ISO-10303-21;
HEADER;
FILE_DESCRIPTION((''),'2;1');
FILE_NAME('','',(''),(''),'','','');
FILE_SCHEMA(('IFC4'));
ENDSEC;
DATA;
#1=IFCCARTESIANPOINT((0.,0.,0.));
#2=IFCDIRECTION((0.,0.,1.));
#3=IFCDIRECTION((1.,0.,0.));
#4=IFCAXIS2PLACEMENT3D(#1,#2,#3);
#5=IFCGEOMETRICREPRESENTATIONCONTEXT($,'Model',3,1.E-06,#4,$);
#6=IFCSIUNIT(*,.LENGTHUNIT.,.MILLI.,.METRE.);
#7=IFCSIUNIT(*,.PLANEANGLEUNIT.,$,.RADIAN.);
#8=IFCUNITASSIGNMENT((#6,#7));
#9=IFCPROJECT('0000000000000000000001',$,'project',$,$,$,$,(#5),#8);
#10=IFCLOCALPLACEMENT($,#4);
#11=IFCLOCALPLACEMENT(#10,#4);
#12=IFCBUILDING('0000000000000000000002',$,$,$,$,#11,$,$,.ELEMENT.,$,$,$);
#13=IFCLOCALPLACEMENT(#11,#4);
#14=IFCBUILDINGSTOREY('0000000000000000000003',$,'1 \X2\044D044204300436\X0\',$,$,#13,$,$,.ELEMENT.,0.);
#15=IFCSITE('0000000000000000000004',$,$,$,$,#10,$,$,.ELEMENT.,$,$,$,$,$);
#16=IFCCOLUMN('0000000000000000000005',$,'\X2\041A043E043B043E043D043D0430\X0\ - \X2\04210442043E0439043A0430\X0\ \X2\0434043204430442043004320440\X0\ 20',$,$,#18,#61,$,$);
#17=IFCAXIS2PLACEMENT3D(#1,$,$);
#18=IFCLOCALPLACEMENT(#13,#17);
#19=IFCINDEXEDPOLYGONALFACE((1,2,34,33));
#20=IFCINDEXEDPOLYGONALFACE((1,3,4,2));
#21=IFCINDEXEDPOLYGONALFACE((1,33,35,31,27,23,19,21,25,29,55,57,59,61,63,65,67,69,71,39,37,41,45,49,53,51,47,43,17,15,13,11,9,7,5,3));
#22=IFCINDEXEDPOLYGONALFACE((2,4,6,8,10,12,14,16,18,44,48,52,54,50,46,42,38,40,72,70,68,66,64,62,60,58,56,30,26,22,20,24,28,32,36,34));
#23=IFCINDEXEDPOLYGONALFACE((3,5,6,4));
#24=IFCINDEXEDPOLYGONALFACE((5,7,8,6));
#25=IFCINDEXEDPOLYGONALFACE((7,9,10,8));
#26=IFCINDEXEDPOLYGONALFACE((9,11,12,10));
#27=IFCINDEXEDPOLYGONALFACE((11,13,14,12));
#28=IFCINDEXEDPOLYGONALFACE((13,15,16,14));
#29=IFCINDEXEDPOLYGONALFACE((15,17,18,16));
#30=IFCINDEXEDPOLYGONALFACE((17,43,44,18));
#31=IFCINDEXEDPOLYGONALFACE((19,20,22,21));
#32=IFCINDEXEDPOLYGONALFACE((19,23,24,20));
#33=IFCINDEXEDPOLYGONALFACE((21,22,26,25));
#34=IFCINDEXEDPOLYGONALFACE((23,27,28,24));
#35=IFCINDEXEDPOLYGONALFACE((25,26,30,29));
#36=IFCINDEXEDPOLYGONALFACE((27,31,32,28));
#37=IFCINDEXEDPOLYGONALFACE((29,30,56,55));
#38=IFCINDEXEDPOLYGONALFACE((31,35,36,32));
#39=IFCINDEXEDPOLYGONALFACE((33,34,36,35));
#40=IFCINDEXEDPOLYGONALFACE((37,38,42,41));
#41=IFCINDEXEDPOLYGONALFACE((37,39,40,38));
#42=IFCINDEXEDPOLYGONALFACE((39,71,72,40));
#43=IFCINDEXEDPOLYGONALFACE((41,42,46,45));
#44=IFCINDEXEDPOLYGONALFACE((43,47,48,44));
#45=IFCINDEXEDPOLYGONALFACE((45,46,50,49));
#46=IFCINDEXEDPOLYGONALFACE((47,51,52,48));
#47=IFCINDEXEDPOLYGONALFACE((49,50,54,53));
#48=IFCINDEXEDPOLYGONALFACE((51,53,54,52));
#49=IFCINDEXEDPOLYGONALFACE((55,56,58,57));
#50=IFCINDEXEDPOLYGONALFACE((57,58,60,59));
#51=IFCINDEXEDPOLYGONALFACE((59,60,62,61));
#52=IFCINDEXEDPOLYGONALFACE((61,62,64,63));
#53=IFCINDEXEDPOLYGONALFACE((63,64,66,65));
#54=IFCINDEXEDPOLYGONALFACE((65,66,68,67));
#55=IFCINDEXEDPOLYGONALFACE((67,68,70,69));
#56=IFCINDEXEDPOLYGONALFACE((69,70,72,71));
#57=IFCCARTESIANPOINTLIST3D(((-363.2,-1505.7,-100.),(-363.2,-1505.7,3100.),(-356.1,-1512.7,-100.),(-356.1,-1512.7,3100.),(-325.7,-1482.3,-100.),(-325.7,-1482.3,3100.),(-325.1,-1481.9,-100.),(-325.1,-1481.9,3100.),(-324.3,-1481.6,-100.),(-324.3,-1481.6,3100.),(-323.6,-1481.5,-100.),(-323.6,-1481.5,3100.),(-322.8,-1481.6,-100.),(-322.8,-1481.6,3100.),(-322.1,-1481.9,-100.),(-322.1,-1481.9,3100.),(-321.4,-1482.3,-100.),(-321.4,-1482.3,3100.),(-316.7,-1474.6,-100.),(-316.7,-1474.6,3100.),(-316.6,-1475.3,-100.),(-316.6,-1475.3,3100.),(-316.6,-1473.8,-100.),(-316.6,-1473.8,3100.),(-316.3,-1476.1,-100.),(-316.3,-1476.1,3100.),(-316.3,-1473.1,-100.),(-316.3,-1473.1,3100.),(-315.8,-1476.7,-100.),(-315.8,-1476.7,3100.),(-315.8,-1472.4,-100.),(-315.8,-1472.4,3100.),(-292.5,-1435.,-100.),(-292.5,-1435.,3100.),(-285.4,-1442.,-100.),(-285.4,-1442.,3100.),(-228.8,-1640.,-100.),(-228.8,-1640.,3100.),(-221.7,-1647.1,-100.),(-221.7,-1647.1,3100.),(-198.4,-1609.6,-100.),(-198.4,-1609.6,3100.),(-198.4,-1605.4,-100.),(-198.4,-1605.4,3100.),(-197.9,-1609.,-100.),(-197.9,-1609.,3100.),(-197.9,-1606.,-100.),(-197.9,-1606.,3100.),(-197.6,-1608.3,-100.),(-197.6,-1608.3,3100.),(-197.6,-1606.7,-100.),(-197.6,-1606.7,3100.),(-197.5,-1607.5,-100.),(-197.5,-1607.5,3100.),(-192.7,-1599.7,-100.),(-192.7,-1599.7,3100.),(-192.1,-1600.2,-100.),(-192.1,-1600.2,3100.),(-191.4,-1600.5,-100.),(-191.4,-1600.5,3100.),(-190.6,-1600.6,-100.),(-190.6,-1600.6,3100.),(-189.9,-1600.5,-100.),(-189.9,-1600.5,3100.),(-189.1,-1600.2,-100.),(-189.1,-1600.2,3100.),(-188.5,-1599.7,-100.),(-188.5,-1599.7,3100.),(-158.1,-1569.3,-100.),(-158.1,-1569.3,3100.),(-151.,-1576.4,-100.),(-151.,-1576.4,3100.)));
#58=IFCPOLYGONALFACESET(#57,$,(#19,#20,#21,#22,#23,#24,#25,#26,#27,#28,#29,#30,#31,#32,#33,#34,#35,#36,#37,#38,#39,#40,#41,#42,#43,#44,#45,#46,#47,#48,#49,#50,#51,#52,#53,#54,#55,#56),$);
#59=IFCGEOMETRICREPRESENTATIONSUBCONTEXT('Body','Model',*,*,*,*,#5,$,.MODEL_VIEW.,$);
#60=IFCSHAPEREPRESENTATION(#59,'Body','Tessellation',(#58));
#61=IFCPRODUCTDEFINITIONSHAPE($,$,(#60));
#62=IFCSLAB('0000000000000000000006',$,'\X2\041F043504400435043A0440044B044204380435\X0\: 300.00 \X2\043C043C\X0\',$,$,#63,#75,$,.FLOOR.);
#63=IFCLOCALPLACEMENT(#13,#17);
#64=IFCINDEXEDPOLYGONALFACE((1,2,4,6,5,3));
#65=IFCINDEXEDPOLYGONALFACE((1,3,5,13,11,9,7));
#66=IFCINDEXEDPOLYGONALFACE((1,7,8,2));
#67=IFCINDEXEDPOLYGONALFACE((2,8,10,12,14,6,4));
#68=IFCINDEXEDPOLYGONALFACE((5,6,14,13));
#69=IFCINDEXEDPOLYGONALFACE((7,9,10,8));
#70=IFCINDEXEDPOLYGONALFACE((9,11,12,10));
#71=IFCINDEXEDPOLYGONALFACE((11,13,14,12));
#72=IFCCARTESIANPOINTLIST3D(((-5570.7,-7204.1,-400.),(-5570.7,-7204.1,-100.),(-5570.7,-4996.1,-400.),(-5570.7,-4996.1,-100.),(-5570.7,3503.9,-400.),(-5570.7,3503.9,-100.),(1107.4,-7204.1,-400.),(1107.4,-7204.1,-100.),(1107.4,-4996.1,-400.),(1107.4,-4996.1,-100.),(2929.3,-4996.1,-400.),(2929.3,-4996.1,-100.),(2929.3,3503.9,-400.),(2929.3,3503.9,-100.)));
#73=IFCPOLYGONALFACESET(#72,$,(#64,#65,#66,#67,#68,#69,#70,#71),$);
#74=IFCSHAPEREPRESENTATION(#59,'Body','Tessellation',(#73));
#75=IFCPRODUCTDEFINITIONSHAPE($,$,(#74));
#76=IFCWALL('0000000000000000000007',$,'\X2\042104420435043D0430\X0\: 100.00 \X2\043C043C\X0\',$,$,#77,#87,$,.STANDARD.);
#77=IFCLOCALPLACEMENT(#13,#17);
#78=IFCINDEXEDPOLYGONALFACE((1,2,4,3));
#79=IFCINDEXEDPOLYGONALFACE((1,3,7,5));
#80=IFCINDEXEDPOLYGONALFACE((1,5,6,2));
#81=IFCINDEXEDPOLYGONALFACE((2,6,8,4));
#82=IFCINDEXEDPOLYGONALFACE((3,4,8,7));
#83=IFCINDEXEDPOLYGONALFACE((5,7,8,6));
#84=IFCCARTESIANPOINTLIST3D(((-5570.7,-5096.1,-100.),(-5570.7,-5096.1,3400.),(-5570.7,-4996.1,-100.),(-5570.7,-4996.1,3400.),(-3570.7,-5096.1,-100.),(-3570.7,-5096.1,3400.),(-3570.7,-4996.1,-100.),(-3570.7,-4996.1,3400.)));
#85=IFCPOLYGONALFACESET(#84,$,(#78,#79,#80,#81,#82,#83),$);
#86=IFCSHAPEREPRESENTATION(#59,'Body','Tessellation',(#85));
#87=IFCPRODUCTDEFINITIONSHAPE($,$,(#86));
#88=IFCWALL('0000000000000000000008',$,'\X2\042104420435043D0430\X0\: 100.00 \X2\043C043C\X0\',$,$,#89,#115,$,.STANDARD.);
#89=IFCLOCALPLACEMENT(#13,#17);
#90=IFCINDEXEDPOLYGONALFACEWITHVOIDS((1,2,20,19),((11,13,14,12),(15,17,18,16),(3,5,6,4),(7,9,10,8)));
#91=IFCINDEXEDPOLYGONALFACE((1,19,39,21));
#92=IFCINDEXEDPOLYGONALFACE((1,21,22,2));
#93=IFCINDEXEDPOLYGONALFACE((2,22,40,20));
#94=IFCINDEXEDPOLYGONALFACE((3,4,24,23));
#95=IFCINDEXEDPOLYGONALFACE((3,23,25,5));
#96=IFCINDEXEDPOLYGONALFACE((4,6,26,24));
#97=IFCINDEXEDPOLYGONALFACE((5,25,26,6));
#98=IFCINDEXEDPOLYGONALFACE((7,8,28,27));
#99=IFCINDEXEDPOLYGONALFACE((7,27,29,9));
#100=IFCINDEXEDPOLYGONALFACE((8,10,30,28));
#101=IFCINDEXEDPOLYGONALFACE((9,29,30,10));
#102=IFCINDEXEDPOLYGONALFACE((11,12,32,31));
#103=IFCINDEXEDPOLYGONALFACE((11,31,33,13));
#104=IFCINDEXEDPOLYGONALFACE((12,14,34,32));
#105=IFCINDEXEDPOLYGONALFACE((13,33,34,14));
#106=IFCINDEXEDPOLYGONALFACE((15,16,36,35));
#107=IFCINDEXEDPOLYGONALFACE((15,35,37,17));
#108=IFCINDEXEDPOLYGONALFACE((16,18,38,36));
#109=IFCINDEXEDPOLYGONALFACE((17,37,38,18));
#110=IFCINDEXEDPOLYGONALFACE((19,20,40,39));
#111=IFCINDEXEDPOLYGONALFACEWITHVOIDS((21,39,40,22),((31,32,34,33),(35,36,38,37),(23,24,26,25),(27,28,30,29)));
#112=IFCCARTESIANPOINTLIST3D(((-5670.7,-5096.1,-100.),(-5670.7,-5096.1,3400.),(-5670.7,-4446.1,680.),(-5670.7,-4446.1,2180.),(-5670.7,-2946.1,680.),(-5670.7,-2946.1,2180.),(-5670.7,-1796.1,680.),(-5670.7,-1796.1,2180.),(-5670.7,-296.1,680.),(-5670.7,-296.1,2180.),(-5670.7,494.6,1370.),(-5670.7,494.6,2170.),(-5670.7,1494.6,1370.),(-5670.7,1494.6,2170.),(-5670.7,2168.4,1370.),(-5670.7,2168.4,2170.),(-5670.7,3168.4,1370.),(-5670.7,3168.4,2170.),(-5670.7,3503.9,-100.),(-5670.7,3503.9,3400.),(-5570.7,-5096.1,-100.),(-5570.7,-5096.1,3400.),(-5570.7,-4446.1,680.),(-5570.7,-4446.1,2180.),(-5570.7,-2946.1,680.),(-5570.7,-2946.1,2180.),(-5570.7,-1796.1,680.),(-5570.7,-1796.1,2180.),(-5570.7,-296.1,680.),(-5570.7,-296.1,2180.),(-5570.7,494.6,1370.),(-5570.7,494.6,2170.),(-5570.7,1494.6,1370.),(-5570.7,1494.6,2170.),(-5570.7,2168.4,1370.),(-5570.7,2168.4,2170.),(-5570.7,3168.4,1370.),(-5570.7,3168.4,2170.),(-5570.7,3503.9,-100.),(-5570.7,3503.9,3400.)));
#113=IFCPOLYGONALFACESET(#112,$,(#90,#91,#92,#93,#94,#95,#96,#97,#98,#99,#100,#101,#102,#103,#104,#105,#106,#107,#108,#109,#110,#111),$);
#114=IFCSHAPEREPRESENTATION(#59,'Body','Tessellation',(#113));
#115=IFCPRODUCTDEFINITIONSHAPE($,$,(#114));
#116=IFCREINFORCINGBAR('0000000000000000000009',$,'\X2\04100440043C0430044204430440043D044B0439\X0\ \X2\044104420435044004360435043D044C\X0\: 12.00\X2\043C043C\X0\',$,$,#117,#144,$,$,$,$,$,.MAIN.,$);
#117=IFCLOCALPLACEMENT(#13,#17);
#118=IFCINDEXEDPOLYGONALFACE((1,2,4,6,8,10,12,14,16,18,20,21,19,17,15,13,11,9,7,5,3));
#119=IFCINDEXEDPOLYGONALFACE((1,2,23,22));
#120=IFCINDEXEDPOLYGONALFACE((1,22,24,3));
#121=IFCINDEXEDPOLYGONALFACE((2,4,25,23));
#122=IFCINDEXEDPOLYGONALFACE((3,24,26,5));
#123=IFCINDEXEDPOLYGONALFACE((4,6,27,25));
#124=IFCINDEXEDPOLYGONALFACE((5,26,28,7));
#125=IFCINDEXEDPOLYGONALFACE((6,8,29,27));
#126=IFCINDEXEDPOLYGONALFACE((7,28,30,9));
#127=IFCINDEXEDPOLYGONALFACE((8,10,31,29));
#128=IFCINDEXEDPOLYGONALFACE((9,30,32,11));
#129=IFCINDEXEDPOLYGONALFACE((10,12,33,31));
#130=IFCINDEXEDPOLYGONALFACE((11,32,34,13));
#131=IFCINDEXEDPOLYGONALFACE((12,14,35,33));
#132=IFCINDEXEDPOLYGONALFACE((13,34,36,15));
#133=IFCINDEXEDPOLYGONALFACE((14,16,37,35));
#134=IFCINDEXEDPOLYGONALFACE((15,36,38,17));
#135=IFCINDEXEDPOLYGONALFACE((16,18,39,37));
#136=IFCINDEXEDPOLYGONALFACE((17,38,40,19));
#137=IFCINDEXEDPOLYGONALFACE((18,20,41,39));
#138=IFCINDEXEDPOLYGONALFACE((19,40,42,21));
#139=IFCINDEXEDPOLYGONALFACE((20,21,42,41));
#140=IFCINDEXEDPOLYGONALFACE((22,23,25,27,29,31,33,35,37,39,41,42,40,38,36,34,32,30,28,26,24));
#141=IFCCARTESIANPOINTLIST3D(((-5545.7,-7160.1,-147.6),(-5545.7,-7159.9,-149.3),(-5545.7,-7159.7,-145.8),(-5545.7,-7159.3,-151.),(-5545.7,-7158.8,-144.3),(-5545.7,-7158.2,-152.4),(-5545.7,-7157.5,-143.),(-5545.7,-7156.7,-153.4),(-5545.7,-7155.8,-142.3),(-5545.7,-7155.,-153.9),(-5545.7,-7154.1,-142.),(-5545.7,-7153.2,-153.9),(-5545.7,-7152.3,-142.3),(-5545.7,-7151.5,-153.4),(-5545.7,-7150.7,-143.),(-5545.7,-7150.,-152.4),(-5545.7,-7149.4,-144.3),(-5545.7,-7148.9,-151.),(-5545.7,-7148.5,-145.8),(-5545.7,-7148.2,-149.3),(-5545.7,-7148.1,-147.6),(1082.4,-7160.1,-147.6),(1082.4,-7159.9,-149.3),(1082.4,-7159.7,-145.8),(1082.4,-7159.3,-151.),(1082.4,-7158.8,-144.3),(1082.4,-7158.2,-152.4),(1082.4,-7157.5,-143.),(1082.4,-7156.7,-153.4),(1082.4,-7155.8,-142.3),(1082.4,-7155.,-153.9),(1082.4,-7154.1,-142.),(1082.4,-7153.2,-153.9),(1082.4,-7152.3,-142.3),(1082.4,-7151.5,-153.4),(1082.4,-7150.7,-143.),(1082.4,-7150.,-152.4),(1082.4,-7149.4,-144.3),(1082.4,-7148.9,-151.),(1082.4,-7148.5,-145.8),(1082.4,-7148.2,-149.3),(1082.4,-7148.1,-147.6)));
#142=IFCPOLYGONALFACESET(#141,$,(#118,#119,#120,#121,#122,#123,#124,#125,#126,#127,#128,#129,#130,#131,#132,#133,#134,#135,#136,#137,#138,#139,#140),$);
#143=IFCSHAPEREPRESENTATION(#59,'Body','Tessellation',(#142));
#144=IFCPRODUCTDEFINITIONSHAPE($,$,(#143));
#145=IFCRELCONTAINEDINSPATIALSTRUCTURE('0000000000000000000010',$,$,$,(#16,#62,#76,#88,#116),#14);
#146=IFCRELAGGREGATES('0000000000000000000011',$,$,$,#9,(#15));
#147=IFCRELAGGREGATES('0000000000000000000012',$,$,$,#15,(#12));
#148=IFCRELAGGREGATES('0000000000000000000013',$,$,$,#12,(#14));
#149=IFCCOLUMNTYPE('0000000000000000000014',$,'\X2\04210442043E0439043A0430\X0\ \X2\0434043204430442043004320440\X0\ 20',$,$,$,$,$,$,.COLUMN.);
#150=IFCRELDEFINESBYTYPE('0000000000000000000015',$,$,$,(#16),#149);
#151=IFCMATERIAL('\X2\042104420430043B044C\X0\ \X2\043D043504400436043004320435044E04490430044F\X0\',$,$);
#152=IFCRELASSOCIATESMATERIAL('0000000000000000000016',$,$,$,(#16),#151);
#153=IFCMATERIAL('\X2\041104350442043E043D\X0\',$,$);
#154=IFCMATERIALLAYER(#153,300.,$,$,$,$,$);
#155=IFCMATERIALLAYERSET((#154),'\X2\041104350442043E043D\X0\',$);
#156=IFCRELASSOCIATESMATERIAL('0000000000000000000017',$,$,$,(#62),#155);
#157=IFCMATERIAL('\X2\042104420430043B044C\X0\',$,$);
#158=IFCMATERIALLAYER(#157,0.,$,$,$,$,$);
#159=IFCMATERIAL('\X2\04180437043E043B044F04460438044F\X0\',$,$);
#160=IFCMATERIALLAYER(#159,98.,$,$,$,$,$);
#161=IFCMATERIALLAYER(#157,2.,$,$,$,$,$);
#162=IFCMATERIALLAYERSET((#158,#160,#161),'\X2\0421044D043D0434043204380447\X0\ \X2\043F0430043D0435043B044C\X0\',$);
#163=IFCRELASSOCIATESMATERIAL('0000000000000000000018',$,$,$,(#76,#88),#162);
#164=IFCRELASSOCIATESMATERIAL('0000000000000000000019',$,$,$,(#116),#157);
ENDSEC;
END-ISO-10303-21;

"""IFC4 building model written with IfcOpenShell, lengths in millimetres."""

from ifc_helpers import new_model, entity, si_unit, frame, origin_with_axes, place, context, subcontext, project, spatial, line, arc, indexed_curve, outline, extrude, source, transform, mapped, material, layer, layer_set, layer_usage, type_object, element, save


model = new_model("IFC4")

# Units and contexts
model_context = context("Model", 3, precision=1e-06, world=origin_with_axes())
body_context = subcontext(model_context, "Body", "Model", "MODEL_VIEW")
ifc_project = project(units=[si_unit("LENGTHUNIT", "METRE", prefix="MILLI"), si_unit("PLANEANGLEUNIT", "RADIAN")], contexts=[model_context])

# Site, building, storey
site_placement = place(None, origin_with_axes())
site = spatial("IfcSite", under=ifc_project, at=site_placement, CompositionType="ELEMENT")
building_placement = place(site_placement, origin_with_axes())
building = spatial("IfcBuilding", under=site, at=building_placement, CompositionType="ELEMENT")
storey_placement = place(building_placement, origin_with_axes())
storey = spatial("IfcBuildingStorey", under=building, at=storey_placement, Name="1 этаж", CompositionType="ELEMENT", Elevation=0.0)

# Column
ifc_material_1 = material(Name="Сталь нержавеющая")
column_type = type_object("IfcColumnType", Name="Стойка двутавр 20", PredefinedType="COLUMN")
shared_shape_1 = source(origin_with_axes(), body_context, "Body", "SweptSolid", [
    extrude(outline(indexed_curve([(-50.0, -100.0), (50.0, -100.0), (50.0, -90.0), (7.0, -90.0), (4.9, -89.1), (4.0, -87.0), (4.0, 87.0), (4.9, 89.1), (7.0, 90.0), (50.0, 90.0), (50.0, 100.0), (-50.0, 100.0), (-50.0, 90.0), (-7.0, 90.0), (-4.9, 89.1), (-4.0, 87.0), (-4.0, -87.0), (-4.9, -89.1), (-7.0, -90.0), (-50.0, -90.0)], segments=[line(1, 2), line(2, 3), line(3, 4), arc(4, 5, 6), line(6, 7), arc(7, 8, 9), line(9, 10), line(10, 11), line(11, 12), line(12, 13), line(13, 14), arc(14, 15, 16), line(16, 17), arc(17, 18, 19), line(19, 20), line(20, 1)])), origin_with_axes(), (0.0, 0.0, 1.0), 3200.0),
])
for number, where, z_axis, x_axis, name in (
    (1, (-257.1, -1541.0, -100.0), (0.0, 0.0, 1.0), (0.707107, 0.707107, 0.0), "Колонна - Стойка двутавр 20"),
):
    element("IfcColumn", number, at=place(storey_placement, frame(where, z_axis=z_axis, x_axis=x_axis)), inside=storey, type_object=column_type, material=ifc_material_1, Name=name, context=body_context, shape_type="MappedRepresentation", body=[
        mapped(shared_shape_1, transform((0.0, 0.0, 0.0), x_axis=(1.0, 0.0, 0.0), y_axis=(0.0, 1.0, 0.0), z_axis=(0.0, 0.0, 1.0), scale=1.0)),
    ])

# Slab
ifc_material_2 = material(Name="Бетон")
ifc_layer_1 = layer(ifc_material_2, 300.0)
ifc_layer_set_1 = layer_set([ifc_layer_1], Name="Бетон")
ifc_layer_usage_1 = layer_usage(ifc_layer_set_1, "AXIS3", "NEGATIVE", -300.0)
slab_placement = place(storey_placement, frame((-5570.7, -4996.1, -400.0), z_axis=(0.0, 0.0, 1.0), x_axis=(0.0, 1.0, 0.0)))
element("IfcSlab", 2, at=slab_placement, inside=storey, material=ifc_layer_usage_1, Name="Перекрытие: 300.00 мм", PredefinedType="FLOOR", context=body_context, shape_type="SweptSolid", body=[
    extrude(outline(indexed_curve([(0.0, 0.0), (8500.0, 0.0), (8500.0, -8500.0), (0.0, -8500.0), (0.0, -6678.1), (-2208.0, -6678.1), (-2208.0, 0.0)], segments=[line(1, 2), line(2, 3), line(3, 4), line(4, 5), line(5, 6), line(6, 7), line(7, 1)])), origin_with_axes(), (0.0, 0.0, 1.0), 300.0),
])

# Wall
ifc_material_3 = material(Name="Сталь")
ifc_layer_2 = layer(ifc_material_3, 0.0)
ifc_material_4 = material(Name="Изоляция")
ifc_layer_3 = layer(ifc_material_4, 98.0)
ifc_layer_4 = layer(ifc_material_3, 2.0)
ifc_layer_set_2 = layer_set([ifc_layer_2, ifc_layer_3, ifc_layer_4], Name="Сэндвич панель")
ifc_layer_usage_2 = layer_usage(ifc_layer_set_2, "AXIS2", "NEGATIVE", 100.0)
wall_1_placement = place(storey_placement, frame((-3570.7, -4996.1, -100.0), z_axis=(0.0, 0.0, 1.0), x_axis=(-1.0, 0.0, 0.0)))
element("IfcWall", 3, at=wall_1_placement, inside=storey, material=ifc_layer_usage_2, Name="Стена: 100.00 мм", PredefinedType="STANDARD", context=body_context, shape_type="SweptSolid", body=[
    extrude(outline(indexed_curve([(0.0, 0.0), (2000.0, 0.0), (2000.0, 100.0), (0.0, 100.0)], segments=[line(1, 2), line(2, 3), line(3, 4), line(4, 1)])), origin_with_axes(), (0.0, 0.0, 1.0), 3500.0),
])

# Wall, openings
wall_2_placement = place(storey_placement, frame((-5570.7, -5096.1, -100.0), z_axis=(0.0, 0.0, 1.0), x_axis=(0.0, 1.0, 0.0)))
wall_2 = element("IfcWall", 4, at=wall_2_placement, inside=storey, material=ifc_layer_usage_2, Name="Стена: 100.00 мм", PredefinedType="STANDARD", context=body_context, shape_type="SweptSolid", body=[
    extrude(outline(indexed_curve([(0.0, 0.0), (8600.0, 0.0), (8600.0, 100.0), (0.0, 100.0)], segments=[line(1, 2), line(2, 3), line(3, 4), line(4, 1)])), origin_with_axes(), (0.0, 0.0, 1.0), 3500.0),
])
opening_1_placement = place(wall_2_placement, frame((2150.0, 100.0, 780.0), z_axis=(0.0, 0.0, 1.0), x_axis=(-1.0, 0.0, 0.0)))
element("IfcOpeningElement", 5, at=opening_1_placement, cuts=wall_2, PredefinedType="OPENING", context=body_context, shape_type="SweptSolid", body=[
    extrude(outline(indexed_curve([(0.0, 0.0), (1500.0, 0.0), (1500.0, 1500.0), (0.0, 1500.0)], segments=[line(1, 2), line(2, 3), line(3, 4), line(4, 1)])), frame((0.0, -5.0, 0.0), z_axis=(0.0, -1.0, 0.0), x_axis=(1.0, 0.0, 0.0)), (0.0, 0.0, -1.0), 110.0),
])
opening_2_placement = place(wall_2_placement, frame((4800.0, 100.0, 780.0), z_axis=(0.0, 0.0, 1.0), x_axis=(-1.0, 0.0, 0.0)))
element("IfcOpeningElement", 6, at=opening_2_placement, cuts=wall_2, PredefinedType="OPENING", context=body_context, shape_type="SweptSolid", body=[
    extrude(outline(indexed_curve([(0.0, 0.0), (1500.0, 0.0), (1500.0, 1500.0), (0.0, 1500.0)], segments=[line(1, 2), line(2, 3), line(3, 4), line(4, 1)])), frame((0.0, -5.0, 0.0), z_axis=(0.0, -1.0, 0.0), x_axis=(1.0, 0.0, 0.0)), (0.0, 0.0, -1.0), 110.0),
])
opening_3_placement = place(wall_2_placement, frame((8264.5, 100.0, 1470.0), z_axis=(0.0, 0.0, 1.0), x_axis=(-1.0, 0.0, 0.0)))
element("IfcOpeningElement", 7, at=opening_3_placement, cuts=wall_2, PredefinedType="OPENING", context=body_context, shape_type="SweptSolid", body=[
    extrude(outline(indexed_curve([(0.0, 0.0), (1000.0, 0.0), (1000.0, 800.0), (0.0, 800.0)], segments=[line(1, 2), line(2, 3), line(3, 4), line(4, 1)])), frame((0.0, -5.0, 0.0), z_axis=(0.0, -1.0, 0.0), x_axis=(1.0, 0.0, 0.0)), (0.0, 0.0, -1.0), 110.0),
])
opening_4_placement = place(wall_2_placement, frame((6590.6, 100.0, 1470.0), z_axis=(0.0, 0.0, 1.0), x_axis=(-1.0, 0.0, 0.0)))
element("IfcOpeningElement", 8, at=opening_4_placement, cuts=wall_2, PredefinedType="OPENING", context=body_context, shape_type="SweptSolid", body=[
    extrude(outline(indexed_curve([(0.0, 0.0), (1000.0, 0.0), (1000.0, 800.0), (0.0, 800.0)], segments=[line(1, 2), line(2, 3), line(3, 4), line(4, 1)])), frame((0.0, -5.0, 0.0), z_axis=(0.0, -1.0, 0.0), x_axis=(1.0, 0.0, 0.0)), (0.0, 0.0, -1.0), 110.0),
])

# Reinforcing bar
shared_shape_2 = source(origin_with_axes(), body_context, "Body", "AdvancedSweptSolid", [
    entity("IfcSweptDiskSolid", entity("IfcIndexedPolyCurve", entity("IfcCartesianPointList3D", [[0.0, 0.0, 0.0], [6628.1, 0.0, 0.0]]), [entity("IfcLineIndex", [1, 2])]), 6.0),
])
reinforcing_bar_1_placement = place(storey_placement, origin_with_axes())
element("IfcReinforcingBar", 9, at=reinforcing_bar_1_placement, inside=storey, material=ifc_material_3, Name="Арматурный стержень: 12.00мм", PredefinedType="MAIN", context=body_context, shape_type="MappedRepresentation", body=[
    mapped(shared_shape_2, transform((-5545.7, -7154.1, -148.0), x_axis=(1.0, 0.0, 0.0), y_axis=(0.0, 1.0, 0.0), z_axis=(0.0, 0.0, 1.0), scale=1.0)),
])

save(model, "model.ifc")
